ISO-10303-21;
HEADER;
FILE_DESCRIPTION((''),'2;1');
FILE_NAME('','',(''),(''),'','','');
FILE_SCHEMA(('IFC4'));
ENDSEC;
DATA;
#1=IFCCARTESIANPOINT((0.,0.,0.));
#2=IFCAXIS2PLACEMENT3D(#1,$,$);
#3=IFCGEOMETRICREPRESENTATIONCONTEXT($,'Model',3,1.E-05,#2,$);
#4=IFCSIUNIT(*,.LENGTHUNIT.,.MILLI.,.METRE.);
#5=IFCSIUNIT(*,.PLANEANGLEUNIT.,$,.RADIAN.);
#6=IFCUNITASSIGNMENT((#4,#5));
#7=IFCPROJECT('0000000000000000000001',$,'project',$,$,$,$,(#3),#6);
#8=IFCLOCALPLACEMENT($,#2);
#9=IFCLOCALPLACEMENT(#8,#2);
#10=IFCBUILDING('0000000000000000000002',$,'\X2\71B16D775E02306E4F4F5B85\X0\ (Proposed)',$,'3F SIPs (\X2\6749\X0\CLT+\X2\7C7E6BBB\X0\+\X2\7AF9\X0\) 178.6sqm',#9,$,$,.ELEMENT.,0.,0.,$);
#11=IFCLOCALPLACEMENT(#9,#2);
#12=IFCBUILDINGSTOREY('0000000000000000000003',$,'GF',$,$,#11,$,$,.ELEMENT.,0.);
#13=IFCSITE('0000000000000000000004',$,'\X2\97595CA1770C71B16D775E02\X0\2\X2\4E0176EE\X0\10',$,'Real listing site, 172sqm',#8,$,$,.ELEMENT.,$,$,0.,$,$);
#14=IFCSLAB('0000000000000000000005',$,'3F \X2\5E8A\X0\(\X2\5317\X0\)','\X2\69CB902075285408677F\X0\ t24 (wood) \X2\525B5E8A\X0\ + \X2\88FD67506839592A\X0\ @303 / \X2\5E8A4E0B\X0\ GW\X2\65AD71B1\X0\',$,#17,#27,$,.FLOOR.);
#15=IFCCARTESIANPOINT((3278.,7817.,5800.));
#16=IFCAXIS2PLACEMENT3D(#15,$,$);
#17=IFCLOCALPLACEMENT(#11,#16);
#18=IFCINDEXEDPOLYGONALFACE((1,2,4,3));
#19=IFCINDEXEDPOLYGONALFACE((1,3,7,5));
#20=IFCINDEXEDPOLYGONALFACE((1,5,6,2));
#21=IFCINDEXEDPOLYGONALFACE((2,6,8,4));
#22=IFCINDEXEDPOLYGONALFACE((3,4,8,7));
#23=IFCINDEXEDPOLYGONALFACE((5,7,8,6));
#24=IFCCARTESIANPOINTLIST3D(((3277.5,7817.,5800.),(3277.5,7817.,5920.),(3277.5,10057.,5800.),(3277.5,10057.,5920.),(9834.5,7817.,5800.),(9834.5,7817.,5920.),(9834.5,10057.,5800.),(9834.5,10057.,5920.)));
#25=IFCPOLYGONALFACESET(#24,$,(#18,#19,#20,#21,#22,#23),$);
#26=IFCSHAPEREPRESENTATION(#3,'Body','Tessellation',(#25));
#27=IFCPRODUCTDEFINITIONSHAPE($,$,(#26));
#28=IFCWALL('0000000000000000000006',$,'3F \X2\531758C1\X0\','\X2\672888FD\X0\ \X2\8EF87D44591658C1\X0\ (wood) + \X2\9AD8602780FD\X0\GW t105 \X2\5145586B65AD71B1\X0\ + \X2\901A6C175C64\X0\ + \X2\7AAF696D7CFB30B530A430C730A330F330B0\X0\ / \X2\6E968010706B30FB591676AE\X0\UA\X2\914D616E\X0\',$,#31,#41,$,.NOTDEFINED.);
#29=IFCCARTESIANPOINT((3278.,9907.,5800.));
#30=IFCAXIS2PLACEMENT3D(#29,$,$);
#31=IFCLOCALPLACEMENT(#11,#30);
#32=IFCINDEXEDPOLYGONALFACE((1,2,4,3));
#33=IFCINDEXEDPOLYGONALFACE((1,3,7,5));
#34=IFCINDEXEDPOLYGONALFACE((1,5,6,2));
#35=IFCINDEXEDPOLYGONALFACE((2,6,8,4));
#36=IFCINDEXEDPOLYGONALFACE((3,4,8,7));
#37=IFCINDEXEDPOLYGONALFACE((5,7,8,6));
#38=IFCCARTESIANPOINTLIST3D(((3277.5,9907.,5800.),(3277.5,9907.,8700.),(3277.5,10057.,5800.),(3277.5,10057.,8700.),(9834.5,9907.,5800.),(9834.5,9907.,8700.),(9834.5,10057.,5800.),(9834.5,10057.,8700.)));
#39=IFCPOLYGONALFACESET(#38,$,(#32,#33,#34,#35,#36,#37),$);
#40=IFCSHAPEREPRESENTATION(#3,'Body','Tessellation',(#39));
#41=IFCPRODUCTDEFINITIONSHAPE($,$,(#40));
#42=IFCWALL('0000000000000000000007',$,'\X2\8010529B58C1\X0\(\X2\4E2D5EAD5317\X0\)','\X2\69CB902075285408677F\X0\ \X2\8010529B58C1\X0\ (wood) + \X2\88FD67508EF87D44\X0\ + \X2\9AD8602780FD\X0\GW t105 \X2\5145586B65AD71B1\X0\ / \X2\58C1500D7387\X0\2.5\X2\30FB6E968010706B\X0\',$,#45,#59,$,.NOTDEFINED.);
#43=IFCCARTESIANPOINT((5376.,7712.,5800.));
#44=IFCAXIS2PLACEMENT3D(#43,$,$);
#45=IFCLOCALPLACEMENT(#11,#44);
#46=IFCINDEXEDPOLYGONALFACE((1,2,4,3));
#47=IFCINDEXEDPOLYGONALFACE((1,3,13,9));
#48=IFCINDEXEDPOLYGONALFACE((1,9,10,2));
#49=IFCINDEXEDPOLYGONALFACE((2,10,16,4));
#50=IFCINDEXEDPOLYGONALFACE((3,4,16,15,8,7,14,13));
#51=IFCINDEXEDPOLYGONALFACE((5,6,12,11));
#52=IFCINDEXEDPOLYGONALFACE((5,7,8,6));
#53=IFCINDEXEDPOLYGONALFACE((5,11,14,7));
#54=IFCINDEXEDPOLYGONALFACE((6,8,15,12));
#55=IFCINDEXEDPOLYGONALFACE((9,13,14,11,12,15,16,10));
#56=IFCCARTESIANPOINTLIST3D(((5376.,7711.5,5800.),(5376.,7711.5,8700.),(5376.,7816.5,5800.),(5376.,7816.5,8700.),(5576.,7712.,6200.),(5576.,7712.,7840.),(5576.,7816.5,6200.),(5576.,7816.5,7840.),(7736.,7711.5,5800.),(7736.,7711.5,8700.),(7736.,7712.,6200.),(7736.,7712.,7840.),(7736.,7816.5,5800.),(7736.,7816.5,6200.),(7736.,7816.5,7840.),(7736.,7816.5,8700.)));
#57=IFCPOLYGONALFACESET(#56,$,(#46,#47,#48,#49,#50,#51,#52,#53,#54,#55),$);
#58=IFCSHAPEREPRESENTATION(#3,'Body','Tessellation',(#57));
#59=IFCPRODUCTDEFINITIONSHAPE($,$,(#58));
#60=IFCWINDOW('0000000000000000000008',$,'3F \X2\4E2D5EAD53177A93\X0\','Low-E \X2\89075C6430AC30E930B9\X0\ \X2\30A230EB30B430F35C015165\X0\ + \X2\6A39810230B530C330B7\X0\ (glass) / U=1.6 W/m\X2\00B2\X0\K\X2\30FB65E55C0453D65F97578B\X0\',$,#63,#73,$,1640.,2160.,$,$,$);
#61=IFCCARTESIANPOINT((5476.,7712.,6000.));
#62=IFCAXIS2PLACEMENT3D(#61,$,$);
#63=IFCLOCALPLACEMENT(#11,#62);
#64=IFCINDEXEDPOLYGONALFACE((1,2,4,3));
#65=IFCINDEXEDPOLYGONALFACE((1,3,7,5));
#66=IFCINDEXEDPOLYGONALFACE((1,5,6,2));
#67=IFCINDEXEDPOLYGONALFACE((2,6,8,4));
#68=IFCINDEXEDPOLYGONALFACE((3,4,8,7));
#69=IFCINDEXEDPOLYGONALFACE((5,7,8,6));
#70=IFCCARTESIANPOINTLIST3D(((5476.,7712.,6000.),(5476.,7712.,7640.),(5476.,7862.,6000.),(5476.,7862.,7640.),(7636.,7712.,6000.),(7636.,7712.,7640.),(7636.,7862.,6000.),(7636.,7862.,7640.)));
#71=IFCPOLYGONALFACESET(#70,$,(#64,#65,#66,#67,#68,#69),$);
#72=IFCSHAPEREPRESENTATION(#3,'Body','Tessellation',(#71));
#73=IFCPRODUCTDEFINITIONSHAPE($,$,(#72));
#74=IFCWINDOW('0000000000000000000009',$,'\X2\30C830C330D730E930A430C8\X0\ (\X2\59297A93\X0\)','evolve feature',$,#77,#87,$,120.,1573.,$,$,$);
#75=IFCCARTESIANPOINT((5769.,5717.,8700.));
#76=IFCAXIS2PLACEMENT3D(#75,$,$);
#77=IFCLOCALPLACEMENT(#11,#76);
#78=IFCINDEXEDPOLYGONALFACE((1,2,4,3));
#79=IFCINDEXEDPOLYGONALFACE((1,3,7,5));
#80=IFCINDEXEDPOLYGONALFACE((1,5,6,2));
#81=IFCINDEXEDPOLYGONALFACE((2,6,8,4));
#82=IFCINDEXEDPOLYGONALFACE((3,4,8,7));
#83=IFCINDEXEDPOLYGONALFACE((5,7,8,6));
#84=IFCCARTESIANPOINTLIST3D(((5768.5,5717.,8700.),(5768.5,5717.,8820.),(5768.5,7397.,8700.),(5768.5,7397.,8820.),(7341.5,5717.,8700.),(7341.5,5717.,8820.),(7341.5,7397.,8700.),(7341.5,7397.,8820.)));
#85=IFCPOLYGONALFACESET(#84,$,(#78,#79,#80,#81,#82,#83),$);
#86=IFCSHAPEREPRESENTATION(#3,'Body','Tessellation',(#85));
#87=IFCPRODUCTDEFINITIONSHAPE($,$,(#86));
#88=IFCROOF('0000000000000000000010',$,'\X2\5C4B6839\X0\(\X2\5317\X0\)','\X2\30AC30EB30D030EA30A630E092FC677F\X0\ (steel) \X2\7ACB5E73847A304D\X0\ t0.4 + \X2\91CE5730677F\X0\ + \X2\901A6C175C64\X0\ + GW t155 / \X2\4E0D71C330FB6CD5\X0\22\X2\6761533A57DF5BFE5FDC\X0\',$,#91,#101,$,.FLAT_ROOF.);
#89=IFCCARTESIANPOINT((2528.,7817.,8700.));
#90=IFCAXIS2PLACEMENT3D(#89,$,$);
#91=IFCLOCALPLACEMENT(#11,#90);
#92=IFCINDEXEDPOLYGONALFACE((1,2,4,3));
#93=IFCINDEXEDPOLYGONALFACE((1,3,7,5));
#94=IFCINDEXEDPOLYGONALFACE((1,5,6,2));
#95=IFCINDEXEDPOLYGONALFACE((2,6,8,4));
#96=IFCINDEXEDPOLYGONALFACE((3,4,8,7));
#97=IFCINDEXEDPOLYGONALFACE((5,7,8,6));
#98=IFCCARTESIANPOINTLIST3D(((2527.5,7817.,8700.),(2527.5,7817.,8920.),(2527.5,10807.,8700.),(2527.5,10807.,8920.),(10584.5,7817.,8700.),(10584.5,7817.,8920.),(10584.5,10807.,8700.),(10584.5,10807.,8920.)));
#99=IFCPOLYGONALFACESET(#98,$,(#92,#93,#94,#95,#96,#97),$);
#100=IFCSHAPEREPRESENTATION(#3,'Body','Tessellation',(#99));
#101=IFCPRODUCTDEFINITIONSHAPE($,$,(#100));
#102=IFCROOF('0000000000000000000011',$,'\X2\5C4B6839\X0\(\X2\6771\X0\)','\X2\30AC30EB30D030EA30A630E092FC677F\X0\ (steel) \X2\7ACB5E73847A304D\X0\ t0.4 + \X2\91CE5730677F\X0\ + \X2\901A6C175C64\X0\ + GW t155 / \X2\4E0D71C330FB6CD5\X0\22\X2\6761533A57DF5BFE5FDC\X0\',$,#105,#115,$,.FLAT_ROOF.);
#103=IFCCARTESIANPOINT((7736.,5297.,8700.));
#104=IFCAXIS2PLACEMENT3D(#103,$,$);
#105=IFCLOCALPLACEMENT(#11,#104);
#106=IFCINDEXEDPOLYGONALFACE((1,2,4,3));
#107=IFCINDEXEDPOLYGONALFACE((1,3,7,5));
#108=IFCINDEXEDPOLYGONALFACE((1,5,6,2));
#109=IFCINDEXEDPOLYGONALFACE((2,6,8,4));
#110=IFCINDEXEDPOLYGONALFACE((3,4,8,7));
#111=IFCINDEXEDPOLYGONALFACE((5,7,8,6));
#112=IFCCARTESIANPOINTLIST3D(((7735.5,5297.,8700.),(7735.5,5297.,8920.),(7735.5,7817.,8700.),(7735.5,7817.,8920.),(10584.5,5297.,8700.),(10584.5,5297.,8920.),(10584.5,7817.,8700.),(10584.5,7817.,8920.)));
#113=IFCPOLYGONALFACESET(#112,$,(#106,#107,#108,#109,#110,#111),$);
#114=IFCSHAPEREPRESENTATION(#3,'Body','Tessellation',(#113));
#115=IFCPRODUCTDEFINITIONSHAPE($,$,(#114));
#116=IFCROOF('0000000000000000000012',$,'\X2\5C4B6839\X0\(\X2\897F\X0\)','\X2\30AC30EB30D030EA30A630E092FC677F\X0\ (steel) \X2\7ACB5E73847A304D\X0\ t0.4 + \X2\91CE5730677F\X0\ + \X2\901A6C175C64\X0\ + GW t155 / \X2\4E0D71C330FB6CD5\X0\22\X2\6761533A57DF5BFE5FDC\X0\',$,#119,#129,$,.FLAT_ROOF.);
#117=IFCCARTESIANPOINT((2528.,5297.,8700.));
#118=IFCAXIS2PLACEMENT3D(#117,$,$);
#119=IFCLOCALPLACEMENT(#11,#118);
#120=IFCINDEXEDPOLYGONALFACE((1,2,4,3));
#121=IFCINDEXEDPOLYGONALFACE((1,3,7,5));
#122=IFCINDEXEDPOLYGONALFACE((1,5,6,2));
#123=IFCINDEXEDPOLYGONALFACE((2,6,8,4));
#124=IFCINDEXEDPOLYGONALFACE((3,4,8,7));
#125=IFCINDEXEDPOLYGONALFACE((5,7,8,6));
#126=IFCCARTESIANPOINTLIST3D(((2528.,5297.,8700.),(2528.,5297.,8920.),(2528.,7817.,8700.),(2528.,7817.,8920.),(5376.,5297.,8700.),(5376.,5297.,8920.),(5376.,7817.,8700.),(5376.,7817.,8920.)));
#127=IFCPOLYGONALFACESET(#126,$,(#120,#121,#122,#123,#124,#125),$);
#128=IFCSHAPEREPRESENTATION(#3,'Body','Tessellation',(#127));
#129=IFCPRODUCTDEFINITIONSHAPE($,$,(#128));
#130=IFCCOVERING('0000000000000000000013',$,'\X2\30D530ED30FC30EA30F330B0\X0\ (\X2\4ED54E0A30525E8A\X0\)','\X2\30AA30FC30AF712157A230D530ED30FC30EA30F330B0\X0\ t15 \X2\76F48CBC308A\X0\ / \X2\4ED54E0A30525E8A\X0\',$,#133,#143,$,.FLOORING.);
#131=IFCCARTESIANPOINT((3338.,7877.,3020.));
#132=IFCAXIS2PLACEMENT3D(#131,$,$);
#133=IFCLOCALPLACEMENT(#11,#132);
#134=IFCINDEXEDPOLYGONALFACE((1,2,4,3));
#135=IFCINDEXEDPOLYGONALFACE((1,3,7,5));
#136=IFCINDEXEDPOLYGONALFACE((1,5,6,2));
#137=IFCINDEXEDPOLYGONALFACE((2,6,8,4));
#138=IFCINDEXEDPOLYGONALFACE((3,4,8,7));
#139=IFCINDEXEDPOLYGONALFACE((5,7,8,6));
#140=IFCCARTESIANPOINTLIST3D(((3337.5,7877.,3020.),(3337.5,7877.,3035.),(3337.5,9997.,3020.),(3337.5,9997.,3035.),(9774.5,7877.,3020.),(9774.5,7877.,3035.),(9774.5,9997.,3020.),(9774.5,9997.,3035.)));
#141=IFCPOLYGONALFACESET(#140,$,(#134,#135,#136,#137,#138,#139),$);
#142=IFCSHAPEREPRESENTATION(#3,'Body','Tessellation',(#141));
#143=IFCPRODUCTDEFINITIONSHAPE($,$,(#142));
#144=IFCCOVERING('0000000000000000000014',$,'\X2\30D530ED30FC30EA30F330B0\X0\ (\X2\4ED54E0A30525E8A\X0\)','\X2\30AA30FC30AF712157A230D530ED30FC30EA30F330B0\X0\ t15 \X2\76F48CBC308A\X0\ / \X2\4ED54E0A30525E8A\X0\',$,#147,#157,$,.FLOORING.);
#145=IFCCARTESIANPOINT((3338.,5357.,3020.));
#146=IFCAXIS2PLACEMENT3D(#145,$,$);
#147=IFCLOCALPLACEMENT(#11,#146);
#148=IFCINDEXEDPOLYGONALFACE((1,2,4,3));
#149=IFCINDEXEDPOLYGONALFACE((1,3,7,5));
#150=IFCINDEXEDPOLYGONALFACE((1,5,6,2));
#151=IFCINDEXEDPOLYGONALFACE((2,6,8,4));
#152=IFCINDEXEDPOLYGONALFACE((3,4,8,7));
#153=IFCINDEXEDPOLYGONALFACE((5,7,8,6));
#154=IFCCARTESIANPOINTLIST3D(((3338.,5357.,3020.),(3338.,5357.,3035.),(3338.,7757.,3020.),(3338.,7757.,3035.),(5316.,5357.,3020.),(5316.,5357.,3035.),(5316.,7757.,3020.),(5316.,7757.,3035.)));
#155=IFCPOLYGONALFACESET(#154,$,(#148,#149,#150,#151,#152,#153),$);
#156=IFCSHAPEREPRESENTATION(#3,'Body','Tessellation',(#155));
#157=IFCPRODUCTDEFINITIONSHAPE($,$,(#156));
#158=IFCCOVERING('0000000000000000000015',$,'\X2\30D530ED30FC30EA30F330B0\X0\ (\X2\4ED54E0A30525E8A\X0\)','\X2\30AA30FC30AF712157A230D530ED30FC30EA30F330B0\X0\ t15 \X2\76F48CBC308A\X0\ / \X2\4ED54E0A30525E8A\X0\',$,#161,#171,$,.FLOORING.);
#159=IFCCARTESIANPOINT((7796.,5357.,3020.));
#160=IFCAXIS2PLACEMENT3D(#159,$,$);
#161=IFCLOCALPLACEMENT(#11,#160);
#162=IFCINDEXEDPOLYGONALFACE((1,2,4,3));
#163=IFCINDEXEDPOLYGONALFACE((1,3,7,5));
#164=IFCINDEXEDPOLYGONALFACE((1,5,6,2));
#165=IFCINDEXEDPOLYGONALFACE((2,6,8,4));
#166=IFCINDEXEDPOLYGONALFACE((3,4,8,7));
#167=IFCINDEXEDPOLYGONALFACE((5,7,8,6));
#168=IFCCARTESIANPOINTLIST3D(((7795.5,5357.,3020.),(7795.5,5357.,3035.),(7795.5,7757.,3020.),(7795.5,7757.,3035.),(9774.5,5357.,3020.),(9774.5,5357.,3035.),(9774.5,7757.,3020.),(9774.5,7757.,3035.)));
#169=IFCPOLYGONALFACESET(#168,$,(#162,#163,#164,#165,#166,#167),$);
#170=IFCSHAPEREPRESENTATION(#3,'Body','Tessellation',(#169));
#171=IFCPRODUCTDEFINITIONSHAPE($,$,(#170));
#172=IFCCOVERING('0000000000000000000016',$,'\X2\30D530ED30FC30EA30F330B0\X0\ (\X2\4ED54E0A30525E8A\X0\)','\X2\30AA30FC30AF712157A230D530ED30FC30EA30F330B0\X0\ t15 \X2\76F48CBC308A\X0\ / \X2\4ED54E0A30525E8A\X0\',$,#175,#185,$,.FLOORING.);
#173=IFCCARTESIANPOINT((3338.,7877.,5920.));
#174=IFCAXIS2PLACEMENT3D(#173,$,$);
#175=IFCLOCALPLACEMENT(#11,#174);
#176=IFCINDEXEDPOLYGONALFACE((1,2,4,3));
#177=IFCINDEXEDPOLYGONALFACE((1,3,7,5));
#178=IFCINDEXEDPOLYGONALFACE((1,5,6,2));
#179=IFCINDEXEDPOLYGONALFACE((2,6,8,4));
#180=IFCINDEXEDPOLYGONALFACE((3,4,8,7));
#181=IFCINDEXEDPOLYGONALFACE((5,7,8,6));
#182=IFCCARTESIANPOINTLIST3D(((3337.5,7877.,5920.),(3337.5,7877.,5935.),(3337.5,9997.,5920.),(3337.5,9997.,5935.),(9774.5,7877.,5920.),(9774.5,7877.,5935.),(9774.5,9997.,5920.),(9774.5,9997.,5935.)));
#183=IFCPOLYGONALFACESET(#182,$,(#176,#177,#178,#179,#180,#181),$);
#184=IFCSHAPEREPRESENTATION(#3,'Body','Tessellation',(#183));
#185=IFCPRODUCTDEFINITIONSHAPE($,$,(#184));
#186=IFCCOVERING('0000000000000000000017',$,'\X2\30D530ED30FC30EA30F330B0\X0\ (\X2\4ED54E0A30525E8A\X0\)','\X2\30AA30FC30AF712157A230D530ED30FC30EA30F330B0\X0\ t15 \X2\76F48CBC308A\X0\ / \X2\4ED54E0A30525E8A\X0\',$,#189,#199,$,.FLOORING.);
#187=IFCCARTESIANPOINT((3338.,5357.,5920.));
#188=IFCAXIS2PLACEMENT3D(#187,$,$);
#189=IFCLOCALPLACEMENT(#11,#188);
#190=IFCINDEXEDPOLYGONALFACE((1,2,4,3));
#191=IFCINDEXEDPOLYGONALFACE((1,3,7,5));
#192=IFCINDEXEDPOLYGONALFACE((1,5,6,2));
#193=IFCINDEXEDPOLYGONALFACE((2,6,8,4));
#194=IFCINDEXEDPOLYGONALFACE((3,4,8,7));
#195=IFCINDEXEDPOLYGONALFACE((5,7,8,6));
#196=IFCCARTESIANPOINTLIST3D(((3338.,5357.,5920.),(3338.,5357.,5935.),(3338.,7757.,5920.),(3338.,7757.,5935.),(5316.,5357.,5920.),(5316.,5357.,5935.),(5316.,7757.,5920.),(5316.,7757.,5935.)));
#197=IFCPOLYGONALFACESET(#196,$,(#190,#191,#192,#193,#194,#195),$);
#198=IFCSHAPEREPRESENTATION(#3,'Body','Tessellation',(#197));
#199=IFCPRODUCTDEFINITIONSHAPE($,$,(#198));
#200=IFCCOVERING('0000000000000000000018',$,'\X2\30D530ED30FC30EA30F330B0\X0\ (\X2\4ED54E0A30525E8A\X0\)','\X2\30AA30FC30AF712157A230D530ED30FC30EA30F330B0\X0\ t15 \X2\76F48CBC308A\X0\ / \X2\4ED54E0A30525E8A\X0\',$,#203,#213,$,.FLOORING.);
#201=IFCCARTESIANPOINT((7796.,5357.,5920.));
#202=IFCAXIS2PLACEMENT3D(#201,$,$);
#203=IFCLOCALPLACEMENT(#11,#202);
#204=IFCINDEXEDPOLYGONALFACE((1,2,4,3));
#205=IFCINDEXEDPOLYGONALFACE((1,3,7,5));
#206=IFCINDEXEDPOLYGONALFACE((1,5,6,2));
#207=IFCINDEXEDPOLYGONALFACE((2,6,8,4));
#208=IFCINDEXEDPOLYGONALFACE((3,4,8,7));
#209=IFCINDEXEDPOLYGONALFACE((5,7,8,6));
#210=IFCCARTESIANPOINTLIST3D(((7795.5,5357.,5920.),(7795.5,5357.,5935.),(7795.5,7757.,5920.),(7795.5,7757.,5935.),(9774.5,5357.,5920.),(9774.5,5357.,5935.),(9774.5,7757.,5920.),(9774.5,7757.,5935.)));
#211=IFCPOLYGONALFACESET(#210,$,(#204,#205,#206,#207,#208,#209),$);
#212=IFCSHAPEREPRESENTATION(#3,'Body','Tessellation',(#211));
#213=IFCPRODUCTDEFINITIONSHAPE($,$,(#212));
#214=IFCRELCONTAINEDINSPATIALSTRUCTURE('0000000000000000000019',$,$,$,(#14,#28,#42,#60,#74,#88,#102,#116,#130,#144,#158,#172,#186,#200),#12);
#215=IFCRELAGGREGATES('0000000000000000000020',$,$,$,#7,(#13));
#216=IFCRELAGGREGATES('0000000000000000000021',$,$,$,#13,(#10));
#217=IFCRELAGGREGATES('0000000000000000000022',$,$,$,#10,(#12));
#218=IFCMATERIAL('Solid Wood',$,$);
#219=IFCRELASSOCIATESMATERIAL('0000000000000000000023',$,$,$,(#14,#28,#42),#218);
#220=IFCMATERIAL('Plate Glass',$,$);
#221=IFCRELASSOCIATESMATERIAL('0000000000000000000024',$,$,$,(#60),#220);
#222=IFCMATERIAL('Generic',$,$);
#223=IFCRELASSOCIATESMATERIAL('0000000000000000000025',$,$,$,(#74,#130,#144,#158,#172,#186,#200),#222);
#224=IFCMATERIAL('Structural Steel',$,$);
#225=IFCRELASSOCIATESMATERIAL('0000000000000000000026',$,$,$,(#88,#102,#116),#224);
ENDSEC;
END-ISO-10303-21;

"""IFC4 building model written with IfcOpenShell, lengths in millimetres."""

from ifc_helpers import new_model, si_unit, frame, frame_2d, origin, place, context, project, spatial, rectangle, extrude, material, element, fill, save


model = new_model("IFC4")

# Units and contexts
model_context = context("Model", 3, precision=1e-05, world=origin())
ifc_project = project(units=[si_unit("LENGTHUNIT", "METRE", prefix="MILLI"), si_unit("PLANEANGLEUNIT", "RADIAN")], contexts=[model_context])

# Site, building, storey
site_placement = place(None, origin())
site = spatial("IfcSite", under=ifc_project, at=site_placement, Name="静岡県熱海市2丁目10", ObjectType="Real listing site, 172sqm", CompositionType="ELEMENT", RefElevation=0.0)
building_placement = place(site_placement, origin())
building = spatial("IfcBuilding", under=site, at=building_placement, Name="熱海市の住宅 (Proposed)", ObjectType="3F SIPs (杉CLT+籾殻+竹) 178.6sqm", CompositionType="ELEMENT", ElevationOfRefHeight=0.0, ElevationOfTerrain=0.0)
storey_placement = place(building_placement, origin())
storey = spatial("IfcBuildingStorey", under=building, at=storey_placement, Name="GF", CompositionType="ELEMENT", Elevation=0.0)

# Slab
ifc_material_1 = material(Name="Solid Wood")
slab_placement = place(storey_placement, frame((3278.0, 7817.0, 5800.0)))
element("IfcSlab", 1, at=slab_placement, inside=storey, material=ifc_material_1, Name="3F 床(北)", Description="構造用合板 t24 (wood) 剛床 + 製材根太 @303 / 床下 GW断熱", PredefinedType="FLOOR", context=model_context, shape_type="SweptSolid", body=[
    extrude(rectangle(XDim=6557.0, YDim=2240.0, at=frame_2d((3278.0, 1120.0))), frame((3278.0, 7817.0, 5800.0)), (0.0, 0.0, 1.0), 120.0),
])

# Wall
wall_1_placement = place(storey_placement, frame((3278.0, 9907.0, 5800.0)))
element("IfcWall", 2, at=wall_1_placement, inside=storey, material=ifc_material_1, Name="3F 北壁", Description="木製 軸組外壁 (wood) + 高性能GW t105 充填断熱 + 通気層 + 窯業系サイディング / 準耐火・外皮UA配慮", PredefinedType="NOTDEFINED", context=model_context, shape_type="SweptSolid", body=[
    extrude(rectangle(XDim=6557.0, YDim=150.0, at=frame_2d((3278.0, 75.0))), frame((3278.0, 9907.0, 5800.0)), (0.0, 0.0, 1.0), 2900.0),
])

# Wall, opening, window
wall_2_placement = place(storey_placement, frame((5376.0, 7712.0, 5800.0)))
wall_2 = element("IfcWall", 3, at=wall_2_placement, inside=storey, material=ifc_material_1, Name="耐力壁(中庭北)", Description="構造用合板 耐力壁 (wood) + 製材軸組 + 高性能GW t105 充填断熱 / 壁倍率2.5・準耐火", PredefinedType="NOTDEFINED", context=model_context, shape_type="SweptSolid", body=[
    extrude(rectangle(XDim=2360.0, YDim=105.0, at=frame_2d((1180.0, 52.0))), frame((5376.0, 7712.0, 5800.0)), (0.0, 0.0, 1.0), 2900.0),
])
opening_placement = place(storey_placement, frame((5476.0, 7712.0, 6000.0)))
opening = element("IfcOpeningElement", 4, at=opening_placement, cuts=wall_2, PredefinedType="NOTDEFINED", context=model_context, shape_type="SweptSolid", body=[
    extrude(rectangle(XDim=2160.0, YDim=150.0, at=frame_2d((1080.0, 75.0))), frame((5476.0, 7712.0, 6000.0)), (0.0, 0.0, 1.0), 1640.0),
])
ifc_material_2 = material(Name="Plate Glass")
window_1_placement = place(storey_placement, frame((5476.0, 7712.0, 6000.0)))
window_1 = element("IfcWindow", 5, at=window_1_placement, inside=storey, material=ifc_material_2, Name="3F 中庭北窓", Description="Low-E 複層ガラス アルゴン封入 + 樹脂サッシ (glass) / U=1.6 W/m²K・日射取得型", OverallHeight=1640.0, OverallWidth=2160.0, context=model_context, shape_type="SweptSolid", body=[
    extrude(rectangle(XDim=2160.0, YDim=150.0, at=frame_2d((1080.0, 75.0))), frame((5476.0, 7712.0, 6000.0)), (0.0, 0.0, 1.0), 1640.0),
])
fill(opening, window_1)

# Window
ifc_material_3 = material(Name="Generic")
window_2_placement = place(storey_placement, frame((5769.0, 5717.0, 8700.0)))
element("IfcWindow", 6, at=window_2_placement, inside=storey, material=ifc_material_3, Name="トップライト (天窓)", Description="evolve feature", OverallHeight=120.0, OverallWidth=1573.0, context=model_context, shape_type="SweptSolid", body=[
    extrude(rectangle(XDim=1573.0, YDim=1680.0, at=frame_2d((786.0, 840.0))), frame((5769.0, 5717.0, 8700.0)), (0.0, 0.0, 1.0), 120.0),
])

# Roofs
ifc_material_4 = material(Name="Structural Steel")
roof_1_placement = place(storey_placement, frame((2528.0, 7817.0, 8700.0)))
element("IfcRoof", 7, at=roof_1_placement, inside=storey, material=ifc_material_4, Name="屋根(北)", Description="ガルバリウム鋼板 (steel) 立平葺き t0.4 + 野地板 + 通気層 + GW t155 / 不燃・法22条区域対応", PredefinedType="FLAT_ROOF", context=model_context, shape_type="SweptSolid", body=[
    extrude(rectangle(XDim=8057.0, YDim=2990.0, at=frame_2d((4028.0, 1495.0))), frame((2528.0, 7817.0, 8700.0)), (0.0, 0.0, 1.0), 220.0),
])
roof_2_placement = place(storey_placement, frame((7736.0, 5297.0, 8700.0)))
element("IfcRoof", 8, at=roof_2_placement, inside=storey, material=ifc_material_4, Name="屋根(東)", Description="ガルバリウム鋼板 (steel) 立平葺き t0.4 + 野地板 + 通気層 + GW t155 / 不燃・法22条区域対応", PredefinedType="FLAT_ROOF", context=model_context, shape_type="SweptSolid", body=[
    extrude(rectangle(XDim=2849.0, YDim=2520.0, at=frame_2d((1424.0, 1260.0))), frame((7736.0, 5297.0, 8700.0)), (0.0, 0.0, 1.0), 220.0),
])
roof_3_placement = place(storey_placement, frame((2528.0, 5297.0, 8700.0)))
element("IfcRoof", 9, at=roof_3_placement, inside=storey, material=ifc_material_4, Name="屋根(西)", Description="ガルバリウム鋼板 (steel) 立平葺き t0.4 + 野地板 + 通気層 + GW t155 / 不燃・法22条区域対応", PredefinedType="FLAT_ROOF", context=model_context, shape_type="SweptSolid", body=[
    extrude(rectangle(XDim=2848.0, YDim=2520.0, at=frame_2d((1424.0, 1260.0))), frame((2528.0, 5297.0, 8700.0)), (0.0, 0.0, 1.0), 220.0),
])

# Coverings
covering_1_placement = place(storey_placement, frame((3338.0, 7877.0, 3020.0)))
element("IfcCovering", 10, at=covering_1_placement, inside=storey, material=ifc_material_3, Name="フローリング (仕上げ床)", Description="オーク無垢フローリング t15 直貼り / 仕上げ床", PredefinedType="FLOORING", context=model_context, shape_type="SweptSolid", body=[
    extrude(rectangle(XDim=6437.0, YDim=2120.0, at=frame_2d((3218.0, 1060.0))), frame((3338.0, 7877.0, 3020.0)), (0.0, 0.0, 1.0), 15.0),
])
covering_2_placement = place(storey_placement, frame((3338.0, 5357.0, 3020.0)))
element("IfcCovering", 11, at=covering_2_placement, inside=storey, material=ifc_material_3, Name="フローリング (仕上げ床)", Description="オーク無垢フローリング t15 直貼り / 仕上げ床", PredefinedType="FLOORING", context=model_context, shape_type="SweptSolid", body=[
    extrude(rectangle(XDim=1978.0, YDim=2400.0, at=frame_2d((989.0, 1200.0))), frame((3338.0, 5357.0, 3020.0)), (0.0, 0.0, 1.0), 15.0),
])
covering_3_placement = place(storey_placement, frame((7796.0, 5357.0, 3020.0)))
element("IfcCovering", 12, at=covering_3_placement, inside=storey, material=ifc_material_3, Name="フローリング (仕上げ床)", Description="オーク無垢フローリング t15 直貼り / 仕上げ床", PredefinedType="FLOORING", context=model_context, shape_type="SweptSolid", body=[
    extrude(rectangle(XDim=1979.0, YDim=2400.0, at=frame_2d((989.0, 1200.0))), frame((7796.0, 5357.0, 3020.0)), (0.0, 0.0, 1.0), 15.0),
])
covering_4_placement = place(storey_placement, frame((3338.0, 7877.0, 5920.0)))
element("IfcCovering", 13, at=covering_4_placement, inside=storey, material=ifc_material_3, Name="フローリング (仕上げ床)", Description="オーク無垢フローリング t15 直貼り / 仕上げ床", PredefinedType="FLOORING", context=model_context, shape_type="SweptSolid", body=[
    extrude(rectangle(XDim=6437.0, YDim=2120.0, at=frame_2d((3218.0, 1060.0))), frame((3338.0, 7877.0, 5920.0)), (0.0, 0.0, 1.0), 15.0),
])
covering_5_placement = place(storey_placement, frame((3338.0, 5357.0, 5920.0)))
element("IfcCovering", 14, at=covering_5_placement, inside=storey, material=ifc_material_3, Name="フローリング (仕上げ床)", Description="オーク無垢フローリング t15 直貼り / 仕上げ床", PredefinedType="FLOORING", context=model_context, shape_type="SweptSolid", body=[
    extrude(rectangle(XDim=1978.0, YDim=2400.0, at=frame_2d((989.0, 1200.0))), frame((3338.0, 5357.0, 5920.0)), (0.0, 0.0, 1.0), 15.0),
])
covering_6_placement = place(storey_placement, frame((7796.0, 5357.0, 5920.0)))
element("IfcCovering", 15, at=covering_6_placement, inside=storey, material=ifc_material_3, Name="フローリング (仕上げ床)", Description="オーク無垢フローリング t15 直貼り / 仕上げ床", PredefinedType="FLOORING", context=model_context, shape_type="SweptSolid", body=[
    extrude(rectangle(XDim=1979.0, YDim=2400.0, at=frame_2d((989.0, 1200.0))), frame((7796.0, 5357.0, 5920.0)), (0.0, 0.0, 1.0), 15.0),
])

save(model, "model.ifc")
